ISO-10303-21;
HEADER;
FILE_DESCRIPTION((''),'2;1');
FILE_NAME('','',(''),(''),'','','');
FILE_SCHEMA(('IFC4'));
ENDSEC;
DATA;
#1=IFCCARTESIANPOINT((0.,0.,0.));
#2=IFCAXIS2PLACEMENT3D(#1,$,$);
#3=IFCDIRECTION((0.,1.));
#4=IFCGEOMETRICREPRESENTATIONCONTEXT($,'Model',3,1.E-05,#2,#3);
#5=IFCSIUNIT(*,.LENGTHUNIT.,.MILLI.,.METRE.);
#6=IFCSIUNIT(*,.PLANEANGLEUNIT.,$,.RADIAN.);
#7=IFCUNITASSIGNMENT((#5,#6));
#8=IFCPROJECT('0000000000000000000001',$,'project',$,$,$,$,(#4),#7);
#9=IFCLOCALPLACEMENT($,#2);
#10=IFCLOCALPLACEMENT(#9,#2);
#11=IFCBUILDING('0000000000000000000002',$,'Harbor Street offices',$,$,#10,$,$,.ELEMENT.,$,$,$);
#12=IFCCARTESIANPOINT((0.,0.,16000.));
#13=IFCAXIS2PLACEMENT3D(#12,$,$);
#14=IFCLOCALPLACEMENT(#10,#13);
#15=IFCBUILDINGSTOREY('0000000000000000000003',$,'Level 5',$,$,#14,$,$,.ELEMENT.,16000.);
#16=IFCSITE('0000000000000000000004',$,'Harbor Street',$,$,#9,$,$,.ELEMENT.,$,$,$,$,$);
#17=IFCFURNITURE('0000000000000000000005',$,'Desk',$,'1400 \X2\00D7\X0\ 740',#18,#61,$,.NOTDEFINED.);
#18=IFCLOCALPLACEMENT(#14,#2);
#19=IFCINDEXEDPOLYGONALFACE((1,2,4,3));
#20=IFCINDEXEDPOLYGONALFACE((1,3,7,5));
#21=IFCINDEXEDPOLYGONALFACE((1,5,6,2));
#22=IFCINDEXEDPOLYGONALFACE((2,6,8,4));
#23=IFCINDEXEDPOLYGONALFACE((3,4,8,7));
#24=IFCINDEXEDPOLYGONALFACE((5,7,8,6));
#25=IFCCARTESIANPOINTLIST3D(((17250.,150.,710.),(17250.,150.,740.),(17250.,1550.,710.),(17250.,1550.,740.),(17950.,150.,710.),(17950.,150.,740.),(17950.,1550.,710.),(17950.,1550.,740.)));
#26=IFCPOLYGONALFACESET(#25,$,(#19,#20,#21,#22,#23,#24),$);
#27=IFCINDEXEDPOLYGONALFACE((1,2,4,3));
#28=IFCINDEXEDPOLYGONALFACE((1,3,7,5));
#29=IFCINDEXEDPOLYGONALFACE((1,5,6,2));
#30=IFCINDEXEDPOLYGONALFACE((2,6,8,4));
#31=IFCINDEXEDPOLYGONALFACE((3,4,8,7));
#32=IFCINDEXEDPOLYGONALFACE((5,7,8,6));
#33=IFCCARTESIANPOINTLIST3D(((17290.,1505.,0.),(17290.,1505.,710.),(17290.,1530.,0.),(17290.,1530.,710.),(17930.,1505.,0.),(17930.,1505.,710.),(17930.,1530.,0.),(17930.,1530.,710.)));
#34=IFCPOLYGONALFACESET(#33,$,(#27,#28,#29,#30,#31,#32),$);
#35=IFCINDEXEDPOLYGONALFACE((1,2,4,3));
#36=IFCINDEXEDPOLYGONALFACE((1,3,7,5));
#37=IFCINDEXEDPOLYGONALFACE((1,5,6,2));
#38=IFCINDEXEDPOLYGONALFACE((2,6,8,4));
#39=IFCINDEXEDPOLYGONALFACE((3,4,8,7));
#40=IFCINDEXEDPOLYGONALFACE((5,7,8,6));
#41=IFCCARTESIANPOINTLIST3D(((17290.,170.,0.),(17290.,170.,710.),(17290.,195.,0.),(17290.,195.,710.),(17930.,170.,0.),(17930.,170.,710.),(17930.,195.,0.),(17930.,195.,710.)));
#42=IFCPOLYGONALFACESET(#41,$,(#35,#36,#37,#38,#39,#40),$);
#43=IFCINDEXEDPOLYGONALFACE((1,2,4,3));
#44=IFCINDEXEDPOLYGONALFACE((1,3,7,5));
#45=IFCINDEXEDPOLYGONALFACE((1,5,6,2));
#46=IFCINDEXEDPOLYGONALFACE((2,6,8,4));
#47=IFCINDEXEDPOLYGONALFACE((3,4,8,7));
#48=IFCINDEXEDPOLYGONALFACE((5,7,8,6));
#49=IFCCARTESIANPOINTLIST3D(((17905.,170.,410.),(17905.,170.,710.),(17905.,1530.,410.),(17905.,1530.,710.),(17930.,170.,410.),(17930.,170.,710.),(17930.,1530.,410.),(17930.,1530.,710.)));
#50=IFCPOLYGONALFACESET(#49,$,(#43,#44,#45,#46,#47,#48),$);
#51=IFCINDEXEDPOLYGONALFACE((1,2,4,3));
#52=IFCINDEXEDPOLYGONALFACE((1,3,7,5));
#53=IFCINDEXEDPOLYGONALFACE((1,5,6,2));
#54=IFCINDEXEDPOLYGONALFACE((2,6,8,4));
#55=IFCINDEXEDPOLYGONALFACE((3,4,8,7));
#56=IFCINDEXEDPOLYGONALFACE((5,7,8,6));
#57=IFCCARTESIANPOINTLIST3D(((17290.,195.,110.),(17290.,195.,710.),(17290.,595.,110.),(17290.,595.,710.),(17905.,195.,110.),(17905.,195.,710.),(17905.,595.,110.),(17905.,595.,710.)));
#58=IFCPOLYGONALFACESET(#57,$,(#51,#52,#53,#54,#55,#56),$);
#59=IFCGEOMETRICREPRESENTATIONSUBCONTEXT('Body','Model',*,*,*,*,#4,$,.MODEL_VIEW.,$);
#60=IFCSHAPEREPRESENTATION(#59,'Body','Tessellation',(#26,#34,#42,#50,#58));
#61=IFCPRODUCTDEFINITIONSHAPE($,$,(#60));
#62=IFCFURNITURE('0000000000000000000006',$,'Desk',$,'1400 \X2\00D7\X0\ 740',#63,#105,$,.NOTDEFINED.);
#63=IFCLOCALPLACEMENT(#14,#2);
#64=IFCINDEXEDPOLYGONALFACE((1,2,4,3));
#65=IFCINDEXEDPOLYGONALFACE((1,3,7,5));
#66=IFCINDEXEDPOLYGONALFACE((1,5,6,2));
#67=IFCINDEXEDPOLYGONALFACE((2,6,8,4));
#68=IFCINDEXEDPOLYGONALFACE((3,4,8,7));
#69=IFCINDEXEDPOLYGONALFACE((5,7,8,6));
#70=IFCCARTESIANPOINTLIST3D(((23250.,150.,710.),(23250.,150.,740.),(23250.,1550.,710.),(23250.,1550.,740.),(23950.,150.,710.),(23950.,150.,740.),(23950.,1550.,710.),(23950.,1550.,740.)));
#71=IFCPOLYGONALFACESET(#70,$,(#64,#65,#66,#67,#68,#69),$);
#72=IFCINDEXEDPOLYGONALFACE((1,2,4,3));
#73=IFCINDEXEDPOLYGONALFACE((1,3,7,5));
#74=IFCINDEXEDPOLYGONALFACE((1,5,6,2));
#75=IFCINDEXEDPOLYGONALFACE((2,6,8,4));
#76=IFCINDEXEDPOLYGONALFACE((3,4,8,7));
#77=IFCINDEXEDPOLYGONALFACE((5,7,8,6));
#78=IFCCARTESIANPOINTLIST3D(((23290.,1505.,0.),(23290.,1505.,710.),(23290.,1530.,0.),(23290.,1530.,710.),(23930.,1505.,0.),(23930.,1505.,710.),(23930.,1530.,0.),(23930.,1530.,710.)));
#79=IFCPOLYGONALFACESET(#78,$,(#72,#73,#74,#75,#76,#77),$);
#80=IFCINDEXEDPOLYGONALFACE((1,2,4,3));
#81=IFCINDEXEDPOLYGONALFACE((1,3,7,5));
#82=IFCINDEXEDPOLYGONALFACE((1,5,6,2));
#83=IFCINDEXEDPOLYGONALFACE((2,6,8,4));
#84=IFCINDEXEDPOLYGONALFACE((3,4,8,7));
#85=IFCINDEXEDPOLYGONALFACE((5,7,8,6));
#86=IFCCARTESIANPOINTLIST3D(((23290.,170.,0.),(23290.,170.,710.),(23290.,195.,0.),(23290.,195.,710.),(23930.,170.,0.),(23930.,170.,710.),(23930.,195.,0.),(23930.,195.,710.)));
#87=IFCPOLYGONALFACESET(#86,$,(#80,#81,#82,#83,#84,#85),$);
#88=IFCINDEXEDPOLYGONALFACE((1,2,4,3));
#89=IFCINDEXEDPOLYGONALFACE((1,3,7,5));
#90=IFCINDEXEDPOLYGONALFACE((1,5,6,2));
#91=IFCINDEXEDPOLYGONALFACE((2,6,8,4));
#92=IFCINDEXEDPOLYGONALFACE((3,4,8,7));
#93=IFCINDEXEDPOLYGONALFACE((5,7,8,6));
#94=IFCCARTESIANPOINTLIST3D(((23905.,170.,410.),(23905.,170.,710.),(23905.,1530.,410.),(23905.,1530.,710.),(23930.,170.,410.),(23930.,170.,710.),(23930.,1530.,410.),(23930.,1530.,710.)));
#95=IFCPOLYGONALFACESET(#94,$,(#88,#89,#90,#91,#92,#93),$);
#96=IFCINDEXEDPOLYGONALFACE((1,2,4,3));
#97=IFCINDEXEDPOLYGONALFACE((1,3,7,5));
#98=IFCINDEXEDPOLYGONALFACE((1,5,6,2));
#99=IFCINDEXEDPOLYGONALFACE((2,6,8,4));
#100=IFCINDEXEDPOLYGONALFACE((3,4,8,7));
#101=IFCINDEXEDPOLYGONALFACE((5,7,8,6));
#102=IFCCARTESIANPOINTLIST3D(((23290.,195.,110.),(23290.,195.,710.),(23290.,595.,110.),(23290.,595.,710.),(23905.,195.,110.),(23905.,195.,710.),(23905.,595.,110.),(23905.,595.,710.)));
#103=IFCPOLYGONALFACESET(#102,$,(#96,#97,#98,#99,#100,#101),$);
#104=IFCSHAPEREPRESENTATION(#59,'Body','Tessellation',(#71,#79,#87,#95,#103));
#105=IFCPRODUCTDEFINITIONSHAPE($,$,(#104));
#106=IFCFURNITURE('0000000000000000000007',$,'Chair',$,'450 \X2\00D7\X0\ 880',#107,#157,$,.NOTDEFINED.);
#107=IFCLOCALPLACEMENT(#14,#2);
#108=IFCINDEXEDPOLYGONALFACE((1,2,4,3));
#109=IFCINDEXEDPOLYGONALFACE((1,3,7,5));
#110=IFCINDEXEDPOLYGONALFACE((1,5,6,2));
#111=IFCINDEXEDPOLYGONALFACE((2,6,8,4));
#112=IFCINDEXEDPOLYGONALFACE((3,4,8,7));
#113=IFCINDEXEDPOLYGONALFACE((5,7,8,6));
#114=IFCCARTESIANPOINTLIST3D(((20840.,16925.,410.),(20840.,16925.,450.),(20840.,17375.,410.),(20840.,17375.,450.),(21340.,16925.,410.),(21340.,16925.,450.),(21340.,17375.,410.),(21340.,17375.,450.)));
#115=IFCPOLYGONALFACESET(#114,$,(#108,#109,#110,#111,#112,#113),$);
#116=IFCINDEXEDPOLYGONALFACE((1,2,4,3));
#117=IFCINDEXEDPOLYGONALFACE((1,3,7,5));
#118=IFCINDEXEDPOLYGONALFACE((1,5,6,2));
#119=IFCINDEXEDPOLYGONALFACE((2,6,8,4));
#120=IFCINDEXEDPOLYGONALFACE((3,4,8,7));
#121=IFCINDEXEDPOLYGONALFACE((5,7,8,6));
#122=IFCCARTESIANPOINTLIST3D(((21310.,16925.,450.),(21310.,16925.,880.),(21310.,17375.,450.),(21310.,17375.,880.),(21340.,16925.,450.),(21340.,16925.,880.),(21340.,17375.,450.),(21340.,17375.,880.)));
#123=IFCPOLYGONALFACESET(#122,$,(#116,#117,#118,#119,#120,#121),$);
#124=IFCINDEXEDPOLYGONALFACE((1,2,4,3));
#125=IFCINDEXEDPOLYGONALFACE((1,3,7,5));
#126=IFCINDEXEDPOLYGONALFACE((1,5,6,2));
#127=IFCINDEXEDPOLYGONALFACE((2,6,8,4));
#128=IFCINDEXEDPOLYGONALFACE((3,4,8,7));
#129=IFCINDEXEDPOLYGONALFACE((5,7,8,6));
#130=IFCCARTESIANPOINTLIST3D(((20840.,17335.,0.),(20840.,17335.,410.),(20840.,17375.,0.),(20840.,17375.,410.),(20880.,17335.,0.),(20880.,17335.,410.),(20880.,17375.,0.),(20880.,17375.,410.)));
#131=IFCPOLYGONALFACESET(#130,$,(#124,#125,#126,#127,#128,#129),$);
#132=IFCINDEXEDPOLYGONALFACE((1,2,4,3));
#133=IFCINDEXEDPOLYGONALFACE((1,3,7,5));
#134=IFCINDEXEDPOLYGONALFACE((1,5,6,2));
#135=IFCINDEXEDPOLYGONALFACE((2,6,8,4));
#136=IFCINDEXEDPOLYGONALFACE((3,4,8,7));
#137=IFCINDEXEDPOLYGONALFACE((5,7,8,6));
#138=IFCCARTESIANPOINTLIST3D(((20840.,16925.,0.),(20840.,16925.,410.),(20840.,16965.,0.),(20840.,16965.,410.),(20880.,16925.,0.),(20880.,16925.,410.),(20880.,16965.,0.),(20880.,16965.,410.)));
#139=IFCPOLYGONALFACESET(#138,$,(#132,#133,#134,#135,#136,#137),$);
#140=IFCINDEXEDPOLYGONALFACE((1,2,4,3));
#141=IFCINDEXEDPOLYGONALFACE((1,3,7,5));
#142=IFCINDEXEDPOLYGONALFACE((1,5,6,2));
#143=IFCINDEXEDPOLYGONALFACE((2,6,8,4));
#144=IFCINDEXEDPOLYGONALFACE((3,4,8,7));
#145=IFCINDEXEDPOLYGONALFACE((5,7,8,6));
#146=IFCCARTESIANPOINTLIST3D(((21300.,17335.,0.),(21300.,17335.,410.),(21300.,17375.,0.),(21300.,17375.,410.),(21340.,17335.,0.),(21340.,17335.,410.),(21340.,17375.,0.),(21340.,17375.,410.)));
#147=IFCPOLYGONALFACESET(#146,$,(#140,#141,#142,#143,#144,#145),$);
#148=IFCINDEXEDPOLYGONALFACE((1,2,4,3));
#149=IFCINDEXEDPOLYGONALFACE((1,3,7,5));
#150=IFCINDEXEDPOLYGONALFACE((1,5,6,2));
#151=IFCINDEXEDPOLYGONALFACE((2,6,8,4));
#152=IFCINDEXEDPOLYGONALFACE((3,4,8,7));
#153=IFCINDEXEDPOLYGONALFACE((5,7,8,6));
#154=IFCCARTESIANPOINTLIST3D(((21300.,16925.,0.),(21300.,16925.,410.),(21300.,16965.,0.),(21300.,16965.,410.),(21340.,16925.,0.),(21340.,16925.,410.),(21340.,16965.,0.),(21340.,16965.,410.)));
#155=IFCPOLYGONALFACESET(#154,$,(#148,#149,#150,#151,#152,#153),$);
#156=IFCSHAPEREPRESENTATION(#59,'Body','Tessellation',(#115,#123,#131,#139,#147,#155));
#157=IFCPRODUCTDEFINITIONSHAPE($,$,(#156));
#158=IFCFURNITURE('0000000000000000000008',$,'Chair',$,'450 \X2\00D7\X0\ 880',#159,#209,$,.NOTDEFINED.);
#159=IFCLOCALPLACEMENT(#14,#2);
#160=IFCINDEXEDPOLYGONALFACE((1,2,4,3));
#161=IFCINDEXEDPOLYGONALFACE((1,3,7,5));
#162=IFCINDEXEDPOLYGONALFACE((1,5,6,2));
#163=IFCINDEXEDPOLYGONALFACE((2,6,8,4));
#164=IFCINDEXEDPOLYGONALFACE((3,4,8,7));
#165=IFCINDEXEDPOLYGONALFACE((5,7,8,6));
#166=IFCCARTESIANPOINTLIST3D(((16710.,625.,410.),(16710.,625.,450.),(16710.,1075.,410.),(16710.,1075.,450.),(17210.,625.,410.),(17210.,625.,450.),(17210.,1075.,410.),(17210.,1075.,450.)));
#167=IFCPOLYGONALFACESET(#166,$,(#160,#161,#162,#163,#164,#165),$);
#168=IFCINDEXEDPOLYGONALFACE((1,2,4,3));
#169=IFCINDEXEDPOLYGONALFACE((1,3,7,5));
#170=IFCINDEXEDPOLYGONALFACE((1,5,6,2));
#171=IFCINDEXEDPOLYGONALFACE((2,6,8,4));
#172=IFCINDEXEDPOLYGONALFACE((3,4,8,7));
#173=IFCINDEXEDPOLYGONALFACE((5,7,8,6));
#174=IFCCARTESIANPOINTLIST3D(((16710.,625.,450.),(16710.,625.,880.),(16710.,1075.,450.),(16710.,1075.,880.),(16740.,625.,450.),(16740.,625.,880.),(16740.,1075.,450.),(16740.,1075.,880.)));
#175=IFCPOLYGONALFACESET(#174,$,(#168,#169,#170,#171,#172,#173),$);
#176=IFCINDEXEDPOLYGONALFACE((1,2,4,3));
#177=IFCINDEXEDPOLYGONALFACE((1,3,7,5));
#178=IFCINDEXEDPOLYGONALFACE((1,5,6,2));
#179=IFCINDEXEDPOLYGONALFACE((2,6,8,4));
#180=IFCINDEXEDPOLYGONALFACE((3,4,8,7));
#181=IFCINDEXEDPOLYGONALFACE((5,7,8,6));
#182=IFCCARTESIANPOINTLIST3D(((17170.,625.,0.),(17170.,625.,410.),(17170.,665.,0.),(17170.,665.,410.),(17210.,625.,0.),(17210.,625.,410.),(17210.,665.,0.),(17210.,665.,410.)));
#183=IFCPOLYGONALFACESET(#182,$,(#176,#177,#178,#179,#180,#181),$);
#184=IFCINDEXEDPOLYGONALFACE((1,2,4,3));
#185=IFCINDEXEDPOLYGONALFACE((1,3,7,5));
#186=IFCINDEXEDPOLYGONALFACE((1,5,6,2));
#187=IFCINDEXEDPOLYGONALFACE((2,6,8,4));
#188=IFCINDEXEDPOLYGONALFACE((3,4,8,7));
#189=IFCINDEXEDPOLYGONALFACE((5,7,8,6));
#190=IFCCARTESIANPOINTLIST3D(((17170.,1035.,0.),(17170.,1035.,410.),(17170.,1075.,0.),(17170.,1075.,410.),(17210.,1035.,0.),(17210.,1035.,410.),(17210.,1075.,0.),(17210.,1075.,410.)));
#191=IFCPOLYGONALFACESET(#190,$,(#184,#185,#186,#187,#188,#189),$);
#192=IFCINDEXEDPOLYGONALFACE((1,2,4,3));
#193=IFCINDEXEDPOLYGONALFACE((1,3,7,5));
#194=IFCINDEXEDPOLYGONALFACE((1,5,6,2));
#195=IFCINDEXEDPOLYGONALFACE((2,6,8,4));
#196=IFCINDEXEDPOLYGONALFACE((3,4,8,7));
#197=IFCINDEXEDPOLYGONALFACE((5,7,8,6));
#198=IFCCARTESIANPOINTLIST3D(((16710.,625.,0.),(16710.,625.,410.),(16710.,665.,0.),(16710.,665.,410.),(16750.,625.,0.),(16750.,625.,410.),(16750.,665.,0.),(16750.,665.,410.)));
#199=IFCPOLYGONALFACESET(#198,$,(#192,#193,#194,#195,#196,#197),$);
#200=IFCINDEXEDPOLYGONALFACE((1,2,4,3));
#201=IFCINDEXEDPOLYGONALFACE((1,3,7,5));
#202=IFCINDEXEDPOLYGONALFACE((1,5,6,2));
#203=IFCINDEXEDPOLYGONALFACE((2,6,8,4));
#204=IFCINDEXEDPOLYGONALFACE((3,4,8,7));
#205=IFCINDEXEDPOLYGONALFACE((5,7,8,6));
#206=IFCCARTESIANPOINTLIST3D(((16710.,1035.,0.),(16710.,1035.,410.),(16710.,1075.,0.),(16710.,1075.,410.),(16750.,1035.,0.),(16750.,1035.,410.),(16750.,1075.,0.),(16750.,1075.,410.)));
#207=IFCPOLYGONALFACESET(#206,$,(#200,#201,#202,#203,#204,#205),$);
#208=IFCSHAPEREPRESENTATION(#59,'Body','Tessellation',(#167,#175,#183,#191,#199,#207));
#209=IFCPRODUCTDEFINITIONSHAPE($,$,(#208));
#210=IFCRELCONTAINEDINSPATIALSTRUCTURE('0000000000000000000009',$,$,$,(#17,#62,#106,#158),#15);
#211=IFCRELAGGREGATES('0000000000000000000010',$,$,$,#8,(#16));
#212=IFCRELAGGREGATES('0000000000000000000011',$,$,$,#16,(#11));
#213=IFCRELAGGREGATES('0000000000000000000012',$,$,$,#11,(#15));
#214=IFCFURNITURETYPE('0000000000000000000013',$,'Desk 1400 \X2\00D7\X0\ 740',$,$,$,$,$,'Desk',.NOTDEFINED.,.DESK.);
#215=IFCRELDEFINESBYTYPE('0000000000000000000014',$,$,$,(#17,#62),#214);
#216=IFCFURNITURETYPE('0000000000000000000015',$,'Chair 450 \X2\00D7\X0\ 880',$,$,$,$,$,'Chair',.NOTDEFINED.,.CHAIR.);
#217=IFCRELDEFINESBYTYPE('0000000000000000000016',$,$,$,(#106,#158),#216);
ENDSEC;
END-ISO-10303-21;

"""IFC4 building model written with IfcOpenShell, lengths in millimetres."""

from ifc_helpers import new_model, si_unit, direction, frame, origin, place, context, subcontext, project, spatial, polyline, outline, extrude, source, transform, mapped, type_object, type_shapes, element, save


model = new_model("IFC4")

# Units and contexts
model_context = context("Model", 3, precision=1e-05, world=origin(), true_north=direction((0.0, 1.0)))
body_context = subcontext(model_context, "Body", "Model", "MODEL_VIEW")
ifc_project = project(units=[si_unit("LENGTHUNIT", "METRE", prefix="MILLI"), si_unit("PLANEANGLEUNIT", "RADIAN")], contexts=[model_context])

# Site, building, storey
site_placement = place(None, origin())
site = spatial("IfcSite", under=ifc_project, at=site_placement, Name="Harbor Street", CompositionType="ELEMENT")
building_placement = place(site_placement, origin())
building = spatial("IfcBuilding", under=site, at=building_placement, Name="Harbor Street offices", CompositionType="ELEMENT")
storey_placement = place(building_placement, frame((0.0, 0.0, 16000.0)))
storey = spatial("IfcBuildingStorey", under=building, at=storey_placement, Name="Level 5", CompositionType="ELEMENT", Elevation=16000.0)

# Furniture
furniture_type_1 = type_object("IfcFurnitureType", Name="Desk 1400 × 740", ElementType="Desk", AssemblyPlace="NOTDEFINED", PredefinedType="DESK")
shared_shape_1 = source(origin(), body_context, "Body", "SweptSolid", [
    extrude(outline(polyline([(-700.0, 0.0), (700.0, 0.0), (700.0, 700.0), (-700.0, 700.0), (-700.0, 0.0)])), frame((0.0, 0.0, 710.0)), (0.0, 0.0, 1.0), 30.0),
    extrude(outline(polyline([(-680.0, 40.0), (-655.0, 40.0), (-655.0, 680.0), (-680.0, 680.0), (-680.0, 40.0)])), origin(), (0.0, 0.0, 1.0), 710.0),
    extrude(outline(polyline([(655.0, 40.0), (680.0, 40.0), (680.0, 680.0), (655.0, 680.0), (655.0, 40.0)])), origin(), (0.0, 0.0, 1.0), 710.0),
    extrude(outline(polyline([(-680.0, 655.0), (680.0, 655.0), (680.0, 680.0), (-680.0, 680.0), (-680.0, 655.0)])), frame((0.0, 0.0, 410.0)), (0.0, 0.0, 1.0), 300.0),
    extrude(outline(polyline([(255.0, 40.0), (655.0, 40.0), (655.0, 655.0), (255.0, 655.0), (255.0, 40.0)])), frame((0.0, 0.0, 110.0)), (0.0, 0.0, 1.0), 600.0),
])
type_shapes(furniture_type_1, [shared_shape_1])
for number, where, z_axis, x_axis, name in (
    (1, (17250.0, 850.0, 0.0), (0.0, 0.0, 1.0), (0.0, -1.0, 0.0), "Desk"),
    (2, (23250.0, 850.0, 0.0), (0.0, 0.0, 1.0), (0.0, -1.0, 0.0), "Desk"),
):
    element("IfcFurniture", number, at=place(storey_placement, frame(where, z_axis=z_axis, x_axis=x_axis)), inside=storey, type_object=furniture_type_1, Name=name, ObjectType="1400 × 740", PredefinedType="NOTDEFINED", context=body_context, shape_type="MappedRepresentation", body=[
        mapped(shared_shape_1, transform((0.0, 0.0, 0.0))),
    ])
furniture_type_2 = type_object("IfcFurnitureType", Name="Chair 450 × 880", ElementType="Chair", AssemblyPlace="NOTDEFINED", PredefinedType="CHAIR")
shared_shape_2 = source(origin(), body_context, "Body", "SweptSolid", [
    extrude(outline(polyline([(-225.0, 0.0), (225.0, 0.0), (225.0, 500.0), (-225.0, 500.0), (-225.0, 0.0)])), frame((0.0, 0.0, 410.0)), (0.0, 0.0, 1.0), 40.0),
    extrude(outline(polyline([(-225.0, 470.0), (225.0, 470.0), (225.0, 500.0), (-225.0, 500.0), (-225.0, 470.0)])), frame((0.0, 0.0, 450.0)), (0.0, 0.0, 1.0), 430.0),
    extrude(outline(polyline([(-225.0, 0.0), (-185.0, 0.0), (-185.0, 40.0), (-225.0, 40.0), (-225.0, 0.0)])), origin(), (0.0, 0.0, 1.0), 410.0),
    extrude(outline(polyline([(185.0, 0.0), (225.0, 0.0), (225.0, 40.0), (185.0, 40.0), (185.0, 0.0)])), origin(), (0.0, 0.0, 1.0), 410.0),
    extrude(outline(polyline([(-225.0, 460.0), (-185.0, 460.0), (-185.0, 500.0), (-225.0, 500.0), (-225.0, 460.0)])), origin(), (0.0, 0.0, 1.0), 410.0),
    extrude(outline(polyline([(185.0, 460.0), (225.0, 460.0), (225.0, 500.0), (185.0, 500.0), (185.0, 460.0)])), origin(), (0.0, 0.0, 1.0), 410.0),
])
type_shapes(furniture_type_2, [shared_shape_2])
for number, where, z_axis, x_axis, name in (
    (3, (20840.0, 17150.0, 0.0), (0.0, 0.0, 1.0), (0.0, -1.0, 0.0), "Chair"),
    (4, (17210.0, 850.0, 0.0), (0.0, 0.0, 1.0), (0.0, 1.0, 0.0), "Chair"),
):
    element("IfcFurniture", number, at=place(storey_placement, frame(where, z_axis=z_axis, x_axis=x_axis)), inside=storey, type_object=furniture_type_2, Name=name, ObjectType="450 × 880", PredefinedType="NOTDEFINED", context=body_context, shape_type="MappedRepresentation", body=[
        mapped(shared_shape_2, transform((0.0, 0.0, 0.0))),
    ])

save(model, "model.ifc")
